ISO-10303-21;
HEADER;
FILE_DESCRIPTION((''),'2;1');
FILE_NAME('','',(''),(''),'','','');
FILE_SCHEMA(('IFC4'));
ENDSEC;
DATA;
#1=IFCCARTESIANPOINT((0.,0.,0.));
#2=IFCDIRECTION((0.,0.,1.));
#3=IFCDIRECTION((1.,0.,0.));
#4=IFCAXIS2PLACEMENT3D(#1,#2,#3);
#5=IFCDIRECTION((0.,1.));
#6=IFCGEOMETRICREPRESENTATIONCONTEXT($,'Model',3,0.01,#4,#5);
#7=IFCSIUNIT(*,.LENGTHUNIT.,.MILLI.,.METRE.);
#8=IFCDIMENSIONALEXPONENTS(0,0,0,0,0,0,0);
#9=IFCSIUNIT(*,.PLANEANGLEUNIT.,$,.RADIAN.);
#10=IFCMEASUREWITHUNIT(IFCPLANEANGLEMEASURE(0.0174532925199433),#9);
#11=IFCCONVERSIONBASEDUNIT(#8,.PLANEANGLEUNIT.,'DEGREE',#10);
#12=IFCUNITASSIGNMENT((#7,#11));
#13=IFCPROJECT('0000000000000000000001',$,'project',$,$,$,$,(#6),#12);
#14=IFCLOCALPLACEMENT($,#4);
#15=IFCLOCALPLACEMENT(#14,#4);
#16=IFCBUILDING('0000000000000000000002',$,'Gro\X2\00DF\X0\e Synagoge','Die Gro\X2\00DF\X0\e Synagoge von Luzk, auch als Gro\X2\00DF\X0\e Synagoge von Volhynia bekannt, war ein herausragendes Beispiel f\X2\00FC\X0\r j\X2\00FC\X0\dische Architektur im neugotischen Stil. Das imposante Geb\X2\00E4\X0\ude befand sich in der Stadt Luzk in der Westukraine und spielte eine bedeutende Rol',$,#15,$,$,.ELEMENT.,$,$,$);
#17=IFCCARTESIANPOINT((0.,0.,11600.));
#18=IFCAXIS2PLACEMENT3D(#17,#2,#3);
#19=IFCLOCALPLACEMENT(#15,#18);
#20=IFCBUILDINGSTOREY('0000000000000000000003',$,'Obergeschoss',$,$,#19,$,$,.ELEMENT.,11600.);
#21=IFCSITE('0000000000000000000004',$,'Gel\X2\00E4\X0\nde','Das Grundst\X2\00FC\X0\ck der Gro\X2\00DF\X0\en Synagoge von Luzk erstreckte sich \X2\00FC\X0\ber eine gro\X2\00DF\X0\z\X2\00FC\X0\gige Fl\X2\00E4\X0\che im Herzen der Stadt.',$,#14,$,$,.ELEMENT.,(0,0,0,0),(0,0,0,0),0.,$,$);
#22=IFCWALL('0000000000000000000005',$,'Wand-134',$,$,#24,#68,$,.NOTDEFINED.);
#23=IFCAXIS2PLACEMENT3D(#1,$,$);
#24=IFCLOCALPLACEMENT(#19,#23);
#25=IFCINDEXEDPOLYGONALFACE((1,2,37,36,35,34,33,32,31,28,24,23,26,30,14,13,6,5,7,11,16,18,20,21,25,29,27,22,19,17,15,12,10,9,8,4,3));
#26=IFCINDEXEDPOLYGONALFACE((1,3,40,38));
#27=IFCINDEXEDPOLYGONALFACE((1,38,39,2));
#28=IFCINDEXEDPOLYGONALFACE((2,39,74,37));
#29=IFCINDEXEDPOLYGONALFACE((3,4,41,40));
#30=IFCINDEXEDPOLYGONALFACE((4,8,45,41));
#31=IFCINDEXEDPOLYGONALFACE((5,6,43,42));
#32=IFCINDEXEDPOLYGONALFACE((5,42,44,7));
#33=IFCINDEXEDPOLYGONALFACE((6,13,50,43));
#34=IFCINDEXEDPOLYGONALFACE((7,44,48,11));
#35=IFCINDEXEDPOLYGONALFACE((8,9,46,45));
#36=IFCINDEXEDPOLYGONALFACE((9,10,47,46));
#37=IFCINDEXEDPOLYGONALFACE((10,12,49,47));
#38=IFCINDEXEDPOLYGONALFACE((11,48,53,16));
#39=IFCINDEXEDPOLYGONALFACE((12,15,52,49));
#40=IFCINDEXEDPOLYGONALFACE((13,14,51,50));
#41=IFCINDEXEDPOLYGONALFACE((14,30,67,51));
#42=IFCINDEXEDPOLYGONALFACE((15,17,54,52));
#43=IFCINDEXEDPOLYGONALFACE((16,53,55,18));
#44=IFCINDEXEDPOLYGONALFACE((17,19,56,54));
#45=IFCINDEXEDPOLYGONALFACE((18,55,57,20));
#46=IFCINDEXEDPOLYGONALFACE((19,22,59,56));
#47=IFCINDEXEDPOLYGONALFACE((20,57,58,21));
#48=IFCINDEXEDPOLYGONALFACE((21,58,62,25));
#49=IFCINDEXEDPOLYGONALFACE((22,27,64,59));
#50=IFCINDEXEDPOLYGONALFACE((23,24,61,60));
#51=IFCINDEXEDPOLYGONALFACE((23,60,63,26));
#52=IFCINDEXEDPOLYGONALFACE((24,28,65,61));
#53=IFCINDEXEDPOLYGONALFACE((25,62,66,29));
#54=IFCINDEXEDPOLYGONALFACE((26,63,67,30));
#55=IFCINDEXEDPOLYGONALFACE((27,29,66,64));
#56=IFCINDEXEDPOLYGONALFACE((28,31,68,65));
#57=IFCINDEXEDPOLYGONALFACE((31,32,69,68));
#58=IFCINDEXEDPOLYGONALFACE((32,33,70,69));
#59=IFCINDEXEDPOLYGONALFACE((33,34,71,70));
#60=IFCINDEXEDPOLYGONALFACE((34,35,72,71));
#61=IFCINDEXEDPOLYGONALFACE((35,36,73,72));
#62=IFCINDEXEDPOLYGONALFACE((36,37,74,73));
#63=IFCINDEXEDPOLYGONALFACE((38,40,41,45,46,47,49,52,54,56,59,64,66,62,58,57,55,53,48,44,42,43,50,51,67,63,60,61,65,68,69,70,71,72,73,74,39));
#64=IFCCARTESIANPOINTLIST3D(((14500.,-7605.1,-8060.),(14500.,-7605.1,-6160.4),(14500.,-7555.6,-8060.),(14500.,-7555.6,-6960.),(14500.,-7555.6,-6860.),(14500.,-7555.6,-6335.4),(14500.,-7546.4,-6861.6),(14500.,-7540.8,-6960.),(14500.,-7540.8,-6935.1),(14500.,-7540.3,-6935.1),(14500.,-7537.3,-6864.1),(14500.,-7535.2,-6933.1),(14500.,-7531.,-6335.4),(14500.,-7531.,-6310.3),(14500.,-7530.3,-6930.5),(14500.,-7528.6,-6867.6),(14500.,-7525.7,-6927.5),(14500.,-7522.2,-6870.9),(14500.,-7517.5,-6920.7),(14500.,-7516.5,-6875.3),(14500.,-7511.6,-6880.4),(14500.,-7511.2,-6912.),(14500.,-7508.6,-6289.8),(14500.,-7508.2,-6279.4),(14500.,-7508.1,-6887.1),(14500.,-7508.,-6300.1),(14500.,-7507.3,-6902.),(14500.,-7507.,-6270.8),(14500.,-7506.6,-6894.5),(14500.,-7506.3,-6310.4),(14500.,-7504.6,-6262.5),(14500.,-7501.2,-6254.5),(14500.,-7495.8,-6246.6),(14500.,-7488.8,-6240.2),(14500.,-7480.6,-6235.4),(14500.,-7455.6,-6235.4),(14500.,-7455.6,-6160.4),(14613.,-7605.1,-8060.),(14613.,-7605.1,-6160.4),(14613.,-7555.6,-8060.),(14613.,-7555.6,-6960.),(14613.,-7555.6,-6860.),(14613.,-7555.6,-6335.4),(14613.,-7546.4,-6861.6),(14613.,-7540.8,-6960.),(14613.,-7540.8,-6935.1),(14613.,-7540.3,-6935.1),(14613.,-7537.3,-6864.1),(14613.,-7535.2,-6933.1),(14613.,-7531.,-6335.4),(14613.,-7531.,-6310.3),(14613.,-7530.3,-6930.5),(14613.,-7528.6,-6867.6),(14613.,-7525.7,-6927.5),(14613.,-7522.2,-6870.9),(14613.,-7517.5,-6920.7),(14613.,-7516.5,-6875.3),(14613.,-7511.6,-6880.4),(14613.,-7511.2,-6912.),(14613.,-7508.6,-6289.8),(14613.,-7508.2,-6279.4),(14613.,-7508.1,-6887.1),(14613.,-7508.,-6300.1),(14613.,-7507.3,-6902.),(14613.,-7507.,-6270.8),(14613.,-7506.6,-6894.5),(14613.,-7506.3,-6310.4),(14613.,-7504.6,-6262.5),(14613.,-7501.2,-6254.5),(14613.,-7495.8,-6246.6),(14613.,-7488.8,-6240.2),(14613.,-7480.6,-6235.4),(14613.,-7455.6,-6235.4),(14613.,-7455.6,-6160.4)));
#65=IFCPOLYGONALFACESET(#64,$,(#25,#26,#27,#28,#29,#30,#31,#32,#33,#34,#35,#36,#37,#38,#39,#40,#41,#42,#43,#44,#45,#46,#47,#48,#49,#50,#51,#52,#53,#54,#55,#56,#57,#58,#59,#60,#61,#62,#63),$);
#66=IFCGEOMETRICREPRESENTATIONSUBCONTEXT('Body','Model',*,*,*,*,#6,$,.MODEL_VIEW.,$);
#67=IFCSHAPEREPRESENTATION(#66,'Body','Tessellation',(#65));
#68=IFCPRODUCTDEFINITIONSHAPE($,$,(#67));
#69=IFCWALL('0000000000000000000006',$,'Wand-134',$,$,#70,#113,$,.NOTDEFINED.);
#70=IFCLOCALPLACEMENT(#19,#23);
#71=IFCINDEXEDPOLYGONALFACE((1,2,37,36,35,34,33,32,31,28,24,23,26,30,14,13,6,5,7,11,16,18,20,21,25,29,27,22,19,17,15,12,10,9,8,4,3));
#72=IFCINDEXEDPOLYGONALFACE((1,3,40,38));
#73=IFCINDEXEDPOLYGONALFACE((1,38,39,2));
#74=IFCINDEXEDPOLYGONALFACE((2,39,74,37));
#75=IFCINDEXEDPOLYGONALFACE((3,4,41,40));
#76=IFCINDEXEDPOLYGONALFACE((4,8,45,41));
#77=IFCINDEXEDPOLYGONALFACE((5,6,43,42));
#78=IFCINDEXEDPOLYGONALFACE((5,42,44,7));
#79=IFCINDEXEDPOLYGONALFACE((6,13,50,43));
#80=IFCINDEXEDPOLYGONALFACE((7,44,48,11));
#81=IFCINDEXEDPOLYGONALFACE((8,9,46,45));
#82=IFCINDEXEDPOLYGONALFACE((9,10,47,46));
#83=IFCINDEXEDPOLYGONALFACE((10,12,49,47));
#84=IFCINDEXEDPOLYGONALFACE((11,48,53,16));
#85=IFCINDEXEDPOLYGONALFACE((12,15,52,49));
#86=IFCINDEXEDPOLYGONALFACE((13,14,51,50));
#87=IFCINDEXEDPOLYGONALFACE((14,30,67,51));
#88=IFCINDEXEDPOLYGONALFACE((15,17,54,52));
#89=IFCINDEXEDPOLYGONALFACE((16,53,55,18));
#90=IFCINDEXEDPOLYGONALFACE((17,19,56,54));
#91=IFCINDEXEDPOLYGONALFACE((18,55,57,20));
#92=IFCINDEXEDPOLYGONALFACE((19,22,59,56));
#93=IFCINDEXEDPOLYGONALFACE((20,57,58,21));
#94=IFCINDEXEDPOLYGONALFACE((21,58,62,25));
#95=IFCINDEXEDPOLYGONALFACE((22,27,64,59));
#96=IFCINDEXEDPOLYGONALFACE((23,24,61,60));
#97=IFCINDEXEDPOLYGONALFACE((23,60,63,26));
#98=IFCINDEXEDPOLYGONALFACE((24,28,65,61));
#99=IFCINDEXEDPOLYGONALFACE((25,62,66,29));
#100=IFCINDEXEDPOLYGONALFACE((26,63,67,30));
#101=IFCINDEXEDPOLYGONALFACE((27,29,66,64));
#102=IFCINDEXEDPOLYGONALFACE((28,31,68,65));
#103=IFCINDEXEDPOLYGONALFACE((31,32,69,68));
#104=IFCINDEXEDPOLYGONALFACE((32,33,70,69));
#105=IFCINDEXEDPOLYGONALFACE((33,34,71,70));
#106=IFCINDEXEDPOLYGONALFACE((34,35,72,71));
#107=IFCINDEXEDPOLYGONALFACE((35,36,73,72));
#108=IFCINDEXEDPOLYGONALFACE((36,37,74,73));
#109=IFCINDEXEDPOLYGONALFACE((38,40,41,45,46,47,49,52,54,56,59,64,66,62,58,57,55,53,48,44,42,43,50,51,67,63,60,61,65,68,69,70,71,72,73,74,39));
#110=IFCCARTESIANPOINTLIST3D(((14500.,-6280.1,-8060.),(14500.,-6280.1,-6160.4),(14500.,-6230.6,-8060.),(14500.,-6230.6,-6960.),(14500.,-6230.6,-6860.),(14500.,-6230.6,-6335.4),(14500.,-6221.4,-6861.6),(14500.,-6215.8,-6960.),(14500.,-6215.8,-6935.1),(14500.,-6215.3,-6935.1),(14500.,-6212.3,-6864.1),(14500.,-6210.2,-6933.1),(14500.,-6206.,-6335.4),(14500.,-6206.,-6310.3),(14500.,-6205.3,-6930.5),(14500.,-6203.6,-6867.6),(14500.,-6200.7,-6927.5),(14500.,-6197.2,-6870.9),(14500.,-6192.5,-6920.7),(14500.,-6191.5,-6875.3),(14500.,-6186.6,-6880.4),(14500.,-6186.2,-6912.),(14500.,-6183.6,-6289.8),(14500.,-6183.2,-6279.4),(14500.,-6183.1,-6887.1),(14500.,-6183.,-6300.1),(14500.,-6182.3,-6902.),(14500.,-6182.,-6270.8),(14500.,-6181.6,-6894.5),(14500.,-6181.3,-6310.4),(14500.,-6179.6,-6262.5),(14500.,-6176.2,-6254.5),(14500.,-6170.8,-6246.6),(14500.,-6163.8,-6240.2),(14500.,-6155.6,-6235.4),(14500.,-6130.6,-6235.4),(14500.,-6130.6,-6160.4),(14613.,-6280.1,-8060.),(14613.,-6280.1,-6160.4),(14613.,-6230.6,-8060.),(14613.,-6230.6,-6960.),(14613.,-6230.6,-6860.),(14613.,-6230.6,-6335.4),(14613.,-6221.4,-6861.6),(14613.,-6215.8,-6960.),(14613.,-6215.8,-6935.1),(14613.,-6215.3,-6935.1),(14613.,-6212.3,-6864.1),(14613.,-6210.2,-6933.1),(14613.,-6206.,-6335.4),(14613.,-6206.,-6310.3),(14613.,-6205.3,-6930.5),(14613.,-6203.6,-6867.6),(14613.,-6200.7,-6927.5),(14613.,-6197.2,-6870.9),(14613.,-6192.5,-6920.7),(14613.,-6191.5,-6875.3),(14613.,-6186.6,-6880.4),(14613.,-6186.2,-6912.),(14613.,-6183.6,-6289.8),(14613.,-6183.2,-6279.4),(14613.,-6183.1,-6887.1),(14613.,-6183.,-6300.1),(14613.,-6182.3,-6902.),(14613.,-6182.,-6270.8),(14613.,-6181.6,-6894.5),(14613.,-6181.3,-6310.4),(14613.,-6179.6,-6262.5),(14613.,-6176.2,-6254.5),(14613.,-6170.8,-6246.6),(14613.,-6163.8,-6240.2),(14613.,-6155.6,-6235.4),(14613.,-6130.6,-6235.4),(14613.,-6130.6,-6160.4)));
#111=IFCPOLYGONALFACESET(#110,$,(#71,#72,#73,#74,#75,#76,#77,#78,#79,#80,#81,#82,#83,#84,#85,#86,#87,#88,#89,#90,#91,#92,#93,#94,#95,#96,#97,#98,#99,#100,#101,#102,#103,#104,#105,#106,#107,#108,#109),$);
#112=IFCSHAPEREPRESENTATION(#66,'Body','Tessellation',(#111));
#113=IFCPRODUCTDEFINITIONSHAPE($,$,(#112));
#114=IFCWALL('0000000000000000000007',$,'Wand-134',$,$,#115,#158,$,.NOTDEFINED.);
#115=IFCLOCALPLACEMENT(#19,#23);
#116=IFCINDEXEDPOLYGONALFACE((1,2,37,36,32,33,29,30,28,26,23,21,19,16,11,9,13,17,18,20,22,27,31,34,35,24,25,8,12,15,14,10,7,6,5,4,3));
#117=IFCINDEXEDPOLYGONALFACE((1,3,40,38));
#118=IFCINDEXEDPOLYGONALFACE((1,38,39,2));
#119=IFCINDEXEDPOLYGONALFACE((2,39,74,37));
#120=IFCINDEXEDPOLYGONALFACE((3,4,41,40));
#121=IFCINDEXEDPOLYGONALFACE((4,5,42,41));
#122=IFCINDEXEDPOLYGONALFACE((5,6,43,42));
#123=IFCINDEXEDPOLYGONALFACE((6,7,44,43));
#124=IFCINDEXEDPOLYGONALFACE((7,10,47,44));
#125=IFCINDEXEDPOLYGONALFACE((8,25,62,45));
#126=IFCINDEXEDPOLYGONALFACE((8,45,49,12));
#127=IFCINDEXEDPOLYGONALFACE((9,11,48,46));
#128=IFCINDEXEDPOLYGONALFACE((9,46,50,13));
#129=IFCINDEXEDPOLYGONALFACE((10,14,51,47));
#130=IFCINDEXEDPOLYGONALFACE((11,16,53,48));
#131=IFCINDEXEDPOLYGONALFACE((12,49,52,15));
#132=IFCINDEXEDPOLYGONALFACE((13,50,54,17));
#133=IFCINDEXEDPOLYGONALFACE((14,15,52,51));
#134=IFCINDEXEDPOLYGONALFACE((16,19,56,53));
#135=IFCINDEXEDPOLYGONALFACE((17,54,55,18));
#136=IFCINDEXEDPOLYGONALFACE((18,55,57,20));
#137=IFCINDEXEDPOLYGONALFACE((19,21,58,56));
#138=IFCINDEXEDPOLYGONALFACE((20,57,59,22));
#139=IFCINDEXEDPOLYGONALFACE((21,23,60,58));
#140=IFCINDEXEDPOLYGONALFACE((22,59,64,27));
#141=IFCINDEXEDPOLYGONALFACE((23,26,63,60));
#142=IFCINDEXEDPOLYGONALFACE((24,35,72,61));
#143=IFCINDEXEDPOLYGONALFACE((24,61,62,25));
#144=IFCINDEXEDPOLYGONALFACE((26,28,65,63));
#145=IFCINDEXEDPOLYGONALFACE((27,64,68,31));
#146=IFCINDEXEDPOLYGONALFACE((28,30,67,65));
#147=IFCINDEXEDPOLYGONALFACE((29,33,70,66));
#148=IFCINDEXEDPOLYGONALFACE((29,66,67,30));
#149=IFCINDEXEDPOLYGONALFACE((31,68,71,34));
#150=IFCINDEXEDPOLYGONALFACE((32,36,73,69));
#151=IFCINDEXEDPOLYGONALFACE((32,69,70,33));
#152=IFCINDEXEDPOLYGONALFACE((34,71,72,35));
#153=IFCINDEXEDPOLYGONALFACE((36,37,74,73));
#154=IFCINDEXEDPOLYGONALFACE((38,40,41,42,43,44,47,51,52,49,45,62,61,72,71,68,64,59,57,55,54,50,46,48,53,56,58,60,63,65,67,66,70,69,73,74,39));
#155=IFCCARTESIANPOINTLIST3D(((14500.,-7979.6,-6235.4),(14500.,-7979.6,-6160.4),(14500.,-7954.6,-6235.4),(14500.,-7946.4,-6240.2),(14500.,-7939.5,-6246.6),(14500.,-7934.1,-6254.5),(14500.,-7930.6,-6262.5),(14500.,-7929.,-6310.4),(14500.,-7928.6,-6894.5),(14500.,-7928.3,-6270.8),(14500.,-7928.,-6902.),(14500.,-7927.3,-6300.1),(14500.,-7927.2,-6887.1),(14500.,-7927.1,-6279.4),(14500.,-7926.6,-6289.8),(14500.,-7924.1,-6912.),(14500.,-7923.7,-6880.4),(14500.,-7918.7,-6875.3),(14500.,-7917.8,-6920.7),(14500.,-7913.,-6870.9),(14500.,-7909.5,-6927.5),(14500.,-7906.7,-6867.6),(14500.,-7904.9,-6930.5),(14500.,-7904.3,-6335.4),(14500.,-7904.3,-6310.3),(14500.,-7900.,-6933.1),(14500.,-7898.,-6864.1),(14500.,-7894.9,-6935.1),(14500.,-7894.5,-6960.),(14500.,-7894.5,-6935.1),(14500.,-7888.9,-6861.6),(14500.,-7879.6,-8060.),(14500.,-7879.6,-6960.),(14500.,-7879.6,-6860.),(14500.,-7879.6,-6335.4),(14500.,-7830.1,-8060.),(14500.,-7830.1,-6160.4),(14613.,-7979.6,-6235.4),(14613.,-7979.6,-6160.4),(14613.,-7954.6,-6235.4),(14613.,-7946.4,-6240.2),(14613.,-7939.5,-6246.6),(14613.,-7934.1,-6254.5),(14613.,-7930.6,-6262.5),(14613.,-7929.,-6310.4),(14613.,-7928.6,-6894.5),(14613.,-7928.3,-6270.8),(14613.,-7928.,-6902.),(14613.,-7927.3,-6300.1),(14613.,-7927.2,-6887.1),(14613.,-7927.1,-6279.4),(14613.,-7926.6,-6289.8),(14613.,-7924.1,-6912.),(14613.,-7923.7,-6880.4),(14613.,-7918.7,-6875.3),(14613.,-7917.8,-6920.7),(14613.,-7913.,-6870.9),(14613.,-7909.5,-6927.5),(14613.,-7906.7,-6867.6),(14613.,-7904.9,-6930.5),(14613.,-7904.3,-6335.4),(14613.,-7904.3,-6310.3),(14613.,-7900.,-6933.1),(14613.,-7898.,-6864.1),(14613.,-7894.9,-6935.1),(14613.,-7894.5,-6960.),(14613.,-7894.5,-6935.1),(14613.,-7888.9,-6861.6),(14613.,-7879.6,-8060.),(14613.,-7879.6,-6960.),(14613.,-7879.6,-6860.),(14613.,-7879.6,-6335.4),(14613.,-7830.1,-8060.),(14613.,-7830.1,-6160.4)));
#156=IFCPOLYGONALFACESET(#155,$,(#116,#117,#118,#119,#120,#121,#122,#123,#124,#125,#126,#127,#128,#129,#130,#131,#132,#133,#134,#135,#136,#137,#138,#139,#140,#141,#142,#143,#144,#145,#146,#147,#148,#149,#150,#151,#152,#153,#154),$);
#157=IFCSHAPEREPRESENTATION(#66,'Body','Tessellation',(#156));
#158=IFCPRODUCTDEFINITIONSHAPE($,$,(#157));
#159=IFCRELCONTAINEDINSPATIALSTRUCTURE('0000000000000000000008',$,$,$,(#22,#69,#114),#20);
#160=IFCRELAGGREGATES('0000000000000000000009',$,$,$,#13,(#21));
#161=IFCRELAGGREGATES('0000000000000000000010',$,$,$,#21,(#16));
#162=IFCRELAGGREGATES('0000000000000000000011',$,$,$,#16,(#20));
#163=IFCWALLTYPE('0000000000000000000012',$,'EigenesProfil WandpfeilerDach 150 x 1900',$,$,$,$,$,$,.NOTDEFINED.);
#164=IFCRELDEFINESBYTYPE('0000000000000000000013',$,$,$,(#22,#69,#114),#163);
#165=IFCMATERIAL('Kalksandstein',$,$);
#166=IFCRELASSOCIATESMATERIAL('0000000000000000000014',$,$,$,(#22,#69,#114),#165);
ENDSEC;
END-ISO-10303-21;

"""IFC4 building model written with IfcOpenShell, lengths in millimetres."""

from ifc_helpers import new_model, entity, si_unit, converted_unit, direction, frame, origin_with_axes, place, context, subcontext, project, spatial, line, arc, indexed_curve, outline, extrude, material, material_profile, profile_set, type_object, element, save


model = new_model("IFC4")

# Units and contexts
model_context = context("Model", 3, precision=0.01, world=origin_with_axes(), true_north=direction((0.0, 1.0)))
body_context = subcontext(model_context, "Body", "Model", "MODEL_VIEW")
ifc_project = project(units=[si_unit("LENGTHUNIT", "METRE", prefix="MILLI"), converted_unit("PLANEANGLEUNIT", "DEGREE", entity("IfcPlaneAngleMeasure", 0.0174532925199433), si_unit("PLANEANGLEUNIT", "RADIAN"), dimensions=[0, 0, 0, 0, 0, 0, 0])], contexts=[model_context])

# Site, building, storey
site_placement = place(None, origin_with_axes())
site = spatial("IfcSite", under=ifc_project, at=site_placement, Name="Gelände", Description="Das Grundstück der Großen Synagoge von Luzk erstreckte sich über eine großzügige Fläche im Herzen der Stadt.", CompositionType="ELEMENT", RefLatitude=(0, 0, 0, 0), RefLongitude=(0, 0, 0, 0), RefElevation=0.0)
building_placement = place(site_placement, origin_with_axes())
building = spatial("IfcBuilding", under=site, at=building_placement, Name="Große Synagoge", Description="Die Große Synagoge von Luzk, auch als Große Synagoge von Volhynia bekannt, war ein herausragendes Beispiel für jüdische Architektur im neugotischen Stil. Das imposante Gebäude befand sich in der Stadt Luzk in der Westukraine und spielte eine bedeutende Rol", CompositionType="ELEMENT")
storey_placement = place(building_placement, frame((0.0, 0.0, 11600.0), z_axis=(0.0, 0.0, 1.0), x_axis=(1.0, 0.0, 0.0)))
storey = spatial("IfcBuildingStorey", under=building, at=storey_placement, Name="Obergeschoss", CompositionType="ELEMENT", Elevation=11600.0)

# Walls
ifc_material_1 = material(Name="Kalksandstein")
ifc_material_profile = material_profile(ifc_material_1, outline(indexed_curve([(74.2, 1749.6), (98.9, 1749.6), (96.7, 1765.0), (97.0, 1780.5), (99.2, 1793.4), (103.9, 1805.5), (112.6, 1816.7), (124.5, 1824.6), (149.5, 1824.6), (149.5, 1899.6), (0.0, 1899.6), (0.0, 0.0), (49.5, 0.0), (49.5, 1100.0), (64.3, 1100.0), (64.3, 1124.9), (64.8, 1124.9), (72.4, 1128.1), (79.4, 1132.4), (91.1, 1143.4), (97.9, 1157.9), (98.0, 1169.2), (93.5, 1179.5), (85.8, 1187.0), (76.6, 1192.3), (63.3, 1197.2), (49.5, 1200.0), (49.5, 1724.6), (74.2, 1724.6)], segments=[line(1, 2), arc(2, 3, 4), arc(4, 5, 6), arc(6, 7, 8), line(8, 9, 10, 11, 12, 13, 14, 15, 16, 17), arc(17, 18, 19), arc(19, 20, 21), arc(21, 22, 23), arc(23, 24, 25), arc(25, 26, 27), line(27, 28, 29, 1)])), Name="Kalksandstein")
ifc_profile_set = profile_set([ifc_material_profile], Name="EigenesProfil WandpfeilerDach")
wall_type_1 = type_object("IfcWallType", Name="EigenesProfil WandpfeilerDach 150 x 1900", PredefinedType="NOTDEFINED")
for number, where, z_axis, x_axis, name in (
    (1, (14500.0, -7605.1, -8060.0), (0.0, 0.0, 1.0), (1.0, 0.0, 0.0), "Wand-134"),
    (2, (14500.0, -6280.1, -8060.0), (0.0, 0.0, 1.0), (1.0, 0.0, 0.0), "Wand-134"),
):
    element("IfcWall", number, at=place(storey_placement, frame(where, z_axis=z_axis, x_axis=x_axis)), inside=storey, type_object=wall_type_1, material=ifc_profile_set, Name=name, PredefinedType="NOTDEFINED", context=body_context, shape_type="SweptSolid", body=[
        extrude(outline(indexed_curve([(74.2, 1749.6), (98.9, 1749.6), (96.7, 1765.0), (97.0, 1780.5), (99.2, 1793.4), (103.9, 1805.5), (112.6, 1816.7), (124.5, 1824.6), (149.5, 1824.6), (149.5, 1899.6), (0.0, 1899.6), (0.0, 0.0), (49.5, 0.0), (49.5, 1100.0), (64.3, 1100.0), (64.3, 1124.9), (64.8, 1124.9), (72.4, 1128.1), (79.4, 1132.4), (91.1, 1143.4), (97.9, 1157.9), (98.0, 1169.2), (93.5, 1179.5), (85.8, 1187.0), (76.6, 1192.3), (63.3, 1197.2), (49.5, 1200.0), (49.5, 1724.6), (74.2, 1724.6)], segments=[line(1, 2), arc(2, 3, 4), arc(4, 5, 6), arc(6, 7, 8), line(8, 9, 10, 11, 12, 13, 14, 15, 16, 17), arc(17, 18, 19), arc(19, 20, 21), arc(21, 22, 23), arc(23, 24, 25), arc(25, 26, 27), line(27, 28, 29, 1)])), frame((0.0, 0.0, 0.0), z_axis=(1.0, 0.0, 0.0), x_axis=(0.0, 1.0, 0.0)), (0.0, 0.0, 1.0), 113.0),
    ])
wall_1_placement = place(storey_placement, frame((14500.0, -7830.1, -8060.0), z_axis=(0.0, 0.0, 1.0), x_axis=(1.0, 0.0, 0.0)))
element("IfcWall", 3, at=wall_1_placement, inside=storey, type_object=wall_type_1, material=ifc_profile_set, Name="Wand-134", PredefinedType="NOTDEFINED", context=body_context, shape_type="SweptSolid", body=[
    extrude(outline(indexed_curve([(74.2, 1749.6), (98.9, 1749.6), (96.7, 1765.0), (97.0, 1780.5), (99.2, 1793.4), (103.9, 1805.5), (112.6, 1816.7), (124.5, 1824.6), (149.5, 1824.6), (149.5, 1899.6), (0.0, 1899.6), (0.0, 0.0), (49.5, 0.0), (49.5, 1100.0), (64.3, 1100.0), (64.3, 1124.9), (64.8, 1124.9), (72.4, 1128.1), (79.4, 1132.4), (91.1, 1143.4), (97.9, 1157.9), (98.0, 1169.2), (93.5, 1179.5), (85.8, 1187.0), (76.6, 1192.3), (63.3, 1197.2), (49.5, 1200.0), (49.5, 1724.6), (74.2, 1724.6)], segments=[line(1, 2), arc(2, 3, 4), arc(4, 5, 6), arc(6, 7, 8), line(8, 9, 10, 11, 12, 13, 14, 15, 16, 17), arc(17, 18, 19), arc(19, 20, 21), arc(21, 22, 23), arc(23, 24, 25), arc(25, 26, 27), line(27, 28, 29, 1)])), frame((0.0, 0.0, 0.0), z_axis=(-1.0, 0.0, 0.0), x_axis=(0.0, -1.0, 0.0)), (0.0, 0.0, -1.0), 113.0),
])

save(model, "model.ifc")
